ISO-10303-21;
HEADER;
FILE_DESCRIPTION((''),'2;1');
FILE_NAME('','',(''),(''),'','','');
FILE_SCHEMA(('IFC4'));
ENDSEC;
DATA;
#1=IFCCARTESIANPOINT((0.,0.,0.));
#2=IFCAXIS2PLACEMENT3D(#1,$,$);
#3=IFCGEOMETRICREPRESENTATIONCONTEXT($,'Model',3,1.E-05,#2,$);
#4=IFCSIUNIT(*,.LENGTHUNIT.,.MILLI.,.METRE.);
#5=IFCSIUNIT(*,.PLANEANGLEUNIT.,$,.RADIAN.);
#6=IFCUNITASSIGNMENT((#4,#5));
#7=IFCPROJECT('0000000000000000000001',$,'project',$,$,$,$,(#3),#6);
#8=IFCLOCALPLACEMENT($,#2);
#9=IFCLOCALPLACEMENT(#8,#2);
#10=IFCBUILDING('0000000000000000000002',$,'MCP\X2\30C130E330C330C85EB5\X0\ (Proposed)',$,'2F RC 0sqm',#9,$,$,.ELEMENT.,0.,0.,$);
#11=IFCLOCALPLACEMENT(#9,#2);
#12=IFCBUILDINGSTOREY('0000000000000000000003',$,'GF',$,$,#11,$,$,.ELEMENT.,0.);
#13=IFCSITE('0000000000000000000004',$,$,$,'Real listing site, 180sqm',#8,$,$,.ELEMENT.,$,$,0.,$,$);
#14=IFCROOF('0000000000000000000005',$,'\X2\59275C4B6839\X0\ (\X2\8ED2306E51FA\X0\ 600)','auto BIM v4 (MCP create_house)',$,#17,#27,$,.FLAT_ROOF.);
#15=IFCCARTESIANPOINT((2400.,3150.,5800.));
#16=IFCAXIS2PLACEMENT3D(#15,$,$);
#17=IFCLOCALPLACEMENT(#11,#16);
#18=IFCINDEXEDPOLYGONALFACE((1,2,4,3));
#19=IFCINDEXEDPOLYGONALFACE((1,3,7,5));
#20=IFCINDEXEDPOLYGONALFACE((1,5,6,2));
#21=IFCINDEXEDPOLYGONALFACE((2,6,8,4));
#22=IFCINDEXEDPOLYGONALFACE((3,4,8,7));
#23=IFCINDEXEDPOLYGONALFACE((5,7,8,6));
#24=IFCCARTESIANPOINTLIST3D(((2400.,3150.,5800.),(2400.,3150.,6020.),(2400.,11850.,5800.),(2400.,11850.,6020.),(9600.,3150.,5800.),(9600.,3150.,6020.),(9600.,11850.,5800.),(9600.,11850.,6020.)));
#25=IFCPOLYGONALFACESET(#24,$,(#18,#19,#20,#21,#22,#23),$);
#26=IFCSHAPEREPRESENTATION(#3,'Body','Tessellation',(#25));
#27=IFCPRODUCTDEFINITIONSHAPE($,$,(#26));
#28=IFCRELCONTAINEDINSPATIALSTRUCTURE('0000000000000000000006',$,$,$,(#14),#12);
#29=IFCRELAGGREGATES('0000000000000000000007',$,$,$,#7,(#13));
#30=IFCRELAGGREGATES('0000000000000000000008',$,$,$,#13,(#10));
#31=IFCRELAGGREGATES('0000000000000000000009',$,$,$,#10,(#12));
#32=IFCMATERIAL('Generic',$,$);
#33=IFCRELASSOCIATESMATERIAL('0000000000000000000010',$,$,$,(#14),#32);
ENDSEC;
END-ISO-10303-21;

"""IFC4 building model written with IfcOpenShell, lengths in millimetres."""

from ifc_helpers import new_model, si_unit, frame, frame_2d, origin, place, context, project, spatial, rectangle, extrude, material, element, save


model = new_model("IFC4")

# Units and contexts
model_context = context("Model", 3, precision=1e-05, world=origin())
ifc_project = project(units=[si_unit("LENGTHUNIT", "METRE", prefix="MILLI"), si_unit("PLANEANGLEUNIT", "RADIAN")], contexts=[model_context])

# Site, building, storey
site_placement = place(None, origin())
site = spatial("IfcSite", under=ifc_project, at=site_placement, ObjectType="Real listing site, 180sqm", CompositionType="ELEMENT", RefElevation=0.0)
building_placement = place(site_placement, origin())
building = spatial("IfcBuilding", under=site, at=building_placement, Name="MCPチャット庵 (Proposed)", ObjectType="2F RC 0sqm", CompositionType="ELEMENT", ElevationOfRefHeight=0.0, ElevationOfTerrain=0.0)
storey_placement = place(building_placement, origin())
storey = spatial("IfcBuildingStorey", under=building, at=storey_placement, Name="GF", CompositionType="ELEMENT", Elevation=0.0)

# Shared definitions
ifc_material = material(Name="Generic")

# Roof
roof_placement = place(storey_placement, frame((2400.0, 3150.0, 5800.0)))
element("IfcRoof", 1, at=roof_placement, inside=storey, material=ifc_material, Name="大屋根 (軒の出 600)", Description="auto BIM v4 (MCP create_house)", PredefinedType="FLAT_ROOF", context=model_context, shape_type="SweptSolid", body=[
    extrude(rectangle(XDim=7200.0, YDim=8700.0, at=frame_2d((3600.0, 4350.0))), frame((2400.0, 3150.0, 5800.0)), (0.0, 0.0, 1.0), 220.0),
])

save(model, "model.ifc")
